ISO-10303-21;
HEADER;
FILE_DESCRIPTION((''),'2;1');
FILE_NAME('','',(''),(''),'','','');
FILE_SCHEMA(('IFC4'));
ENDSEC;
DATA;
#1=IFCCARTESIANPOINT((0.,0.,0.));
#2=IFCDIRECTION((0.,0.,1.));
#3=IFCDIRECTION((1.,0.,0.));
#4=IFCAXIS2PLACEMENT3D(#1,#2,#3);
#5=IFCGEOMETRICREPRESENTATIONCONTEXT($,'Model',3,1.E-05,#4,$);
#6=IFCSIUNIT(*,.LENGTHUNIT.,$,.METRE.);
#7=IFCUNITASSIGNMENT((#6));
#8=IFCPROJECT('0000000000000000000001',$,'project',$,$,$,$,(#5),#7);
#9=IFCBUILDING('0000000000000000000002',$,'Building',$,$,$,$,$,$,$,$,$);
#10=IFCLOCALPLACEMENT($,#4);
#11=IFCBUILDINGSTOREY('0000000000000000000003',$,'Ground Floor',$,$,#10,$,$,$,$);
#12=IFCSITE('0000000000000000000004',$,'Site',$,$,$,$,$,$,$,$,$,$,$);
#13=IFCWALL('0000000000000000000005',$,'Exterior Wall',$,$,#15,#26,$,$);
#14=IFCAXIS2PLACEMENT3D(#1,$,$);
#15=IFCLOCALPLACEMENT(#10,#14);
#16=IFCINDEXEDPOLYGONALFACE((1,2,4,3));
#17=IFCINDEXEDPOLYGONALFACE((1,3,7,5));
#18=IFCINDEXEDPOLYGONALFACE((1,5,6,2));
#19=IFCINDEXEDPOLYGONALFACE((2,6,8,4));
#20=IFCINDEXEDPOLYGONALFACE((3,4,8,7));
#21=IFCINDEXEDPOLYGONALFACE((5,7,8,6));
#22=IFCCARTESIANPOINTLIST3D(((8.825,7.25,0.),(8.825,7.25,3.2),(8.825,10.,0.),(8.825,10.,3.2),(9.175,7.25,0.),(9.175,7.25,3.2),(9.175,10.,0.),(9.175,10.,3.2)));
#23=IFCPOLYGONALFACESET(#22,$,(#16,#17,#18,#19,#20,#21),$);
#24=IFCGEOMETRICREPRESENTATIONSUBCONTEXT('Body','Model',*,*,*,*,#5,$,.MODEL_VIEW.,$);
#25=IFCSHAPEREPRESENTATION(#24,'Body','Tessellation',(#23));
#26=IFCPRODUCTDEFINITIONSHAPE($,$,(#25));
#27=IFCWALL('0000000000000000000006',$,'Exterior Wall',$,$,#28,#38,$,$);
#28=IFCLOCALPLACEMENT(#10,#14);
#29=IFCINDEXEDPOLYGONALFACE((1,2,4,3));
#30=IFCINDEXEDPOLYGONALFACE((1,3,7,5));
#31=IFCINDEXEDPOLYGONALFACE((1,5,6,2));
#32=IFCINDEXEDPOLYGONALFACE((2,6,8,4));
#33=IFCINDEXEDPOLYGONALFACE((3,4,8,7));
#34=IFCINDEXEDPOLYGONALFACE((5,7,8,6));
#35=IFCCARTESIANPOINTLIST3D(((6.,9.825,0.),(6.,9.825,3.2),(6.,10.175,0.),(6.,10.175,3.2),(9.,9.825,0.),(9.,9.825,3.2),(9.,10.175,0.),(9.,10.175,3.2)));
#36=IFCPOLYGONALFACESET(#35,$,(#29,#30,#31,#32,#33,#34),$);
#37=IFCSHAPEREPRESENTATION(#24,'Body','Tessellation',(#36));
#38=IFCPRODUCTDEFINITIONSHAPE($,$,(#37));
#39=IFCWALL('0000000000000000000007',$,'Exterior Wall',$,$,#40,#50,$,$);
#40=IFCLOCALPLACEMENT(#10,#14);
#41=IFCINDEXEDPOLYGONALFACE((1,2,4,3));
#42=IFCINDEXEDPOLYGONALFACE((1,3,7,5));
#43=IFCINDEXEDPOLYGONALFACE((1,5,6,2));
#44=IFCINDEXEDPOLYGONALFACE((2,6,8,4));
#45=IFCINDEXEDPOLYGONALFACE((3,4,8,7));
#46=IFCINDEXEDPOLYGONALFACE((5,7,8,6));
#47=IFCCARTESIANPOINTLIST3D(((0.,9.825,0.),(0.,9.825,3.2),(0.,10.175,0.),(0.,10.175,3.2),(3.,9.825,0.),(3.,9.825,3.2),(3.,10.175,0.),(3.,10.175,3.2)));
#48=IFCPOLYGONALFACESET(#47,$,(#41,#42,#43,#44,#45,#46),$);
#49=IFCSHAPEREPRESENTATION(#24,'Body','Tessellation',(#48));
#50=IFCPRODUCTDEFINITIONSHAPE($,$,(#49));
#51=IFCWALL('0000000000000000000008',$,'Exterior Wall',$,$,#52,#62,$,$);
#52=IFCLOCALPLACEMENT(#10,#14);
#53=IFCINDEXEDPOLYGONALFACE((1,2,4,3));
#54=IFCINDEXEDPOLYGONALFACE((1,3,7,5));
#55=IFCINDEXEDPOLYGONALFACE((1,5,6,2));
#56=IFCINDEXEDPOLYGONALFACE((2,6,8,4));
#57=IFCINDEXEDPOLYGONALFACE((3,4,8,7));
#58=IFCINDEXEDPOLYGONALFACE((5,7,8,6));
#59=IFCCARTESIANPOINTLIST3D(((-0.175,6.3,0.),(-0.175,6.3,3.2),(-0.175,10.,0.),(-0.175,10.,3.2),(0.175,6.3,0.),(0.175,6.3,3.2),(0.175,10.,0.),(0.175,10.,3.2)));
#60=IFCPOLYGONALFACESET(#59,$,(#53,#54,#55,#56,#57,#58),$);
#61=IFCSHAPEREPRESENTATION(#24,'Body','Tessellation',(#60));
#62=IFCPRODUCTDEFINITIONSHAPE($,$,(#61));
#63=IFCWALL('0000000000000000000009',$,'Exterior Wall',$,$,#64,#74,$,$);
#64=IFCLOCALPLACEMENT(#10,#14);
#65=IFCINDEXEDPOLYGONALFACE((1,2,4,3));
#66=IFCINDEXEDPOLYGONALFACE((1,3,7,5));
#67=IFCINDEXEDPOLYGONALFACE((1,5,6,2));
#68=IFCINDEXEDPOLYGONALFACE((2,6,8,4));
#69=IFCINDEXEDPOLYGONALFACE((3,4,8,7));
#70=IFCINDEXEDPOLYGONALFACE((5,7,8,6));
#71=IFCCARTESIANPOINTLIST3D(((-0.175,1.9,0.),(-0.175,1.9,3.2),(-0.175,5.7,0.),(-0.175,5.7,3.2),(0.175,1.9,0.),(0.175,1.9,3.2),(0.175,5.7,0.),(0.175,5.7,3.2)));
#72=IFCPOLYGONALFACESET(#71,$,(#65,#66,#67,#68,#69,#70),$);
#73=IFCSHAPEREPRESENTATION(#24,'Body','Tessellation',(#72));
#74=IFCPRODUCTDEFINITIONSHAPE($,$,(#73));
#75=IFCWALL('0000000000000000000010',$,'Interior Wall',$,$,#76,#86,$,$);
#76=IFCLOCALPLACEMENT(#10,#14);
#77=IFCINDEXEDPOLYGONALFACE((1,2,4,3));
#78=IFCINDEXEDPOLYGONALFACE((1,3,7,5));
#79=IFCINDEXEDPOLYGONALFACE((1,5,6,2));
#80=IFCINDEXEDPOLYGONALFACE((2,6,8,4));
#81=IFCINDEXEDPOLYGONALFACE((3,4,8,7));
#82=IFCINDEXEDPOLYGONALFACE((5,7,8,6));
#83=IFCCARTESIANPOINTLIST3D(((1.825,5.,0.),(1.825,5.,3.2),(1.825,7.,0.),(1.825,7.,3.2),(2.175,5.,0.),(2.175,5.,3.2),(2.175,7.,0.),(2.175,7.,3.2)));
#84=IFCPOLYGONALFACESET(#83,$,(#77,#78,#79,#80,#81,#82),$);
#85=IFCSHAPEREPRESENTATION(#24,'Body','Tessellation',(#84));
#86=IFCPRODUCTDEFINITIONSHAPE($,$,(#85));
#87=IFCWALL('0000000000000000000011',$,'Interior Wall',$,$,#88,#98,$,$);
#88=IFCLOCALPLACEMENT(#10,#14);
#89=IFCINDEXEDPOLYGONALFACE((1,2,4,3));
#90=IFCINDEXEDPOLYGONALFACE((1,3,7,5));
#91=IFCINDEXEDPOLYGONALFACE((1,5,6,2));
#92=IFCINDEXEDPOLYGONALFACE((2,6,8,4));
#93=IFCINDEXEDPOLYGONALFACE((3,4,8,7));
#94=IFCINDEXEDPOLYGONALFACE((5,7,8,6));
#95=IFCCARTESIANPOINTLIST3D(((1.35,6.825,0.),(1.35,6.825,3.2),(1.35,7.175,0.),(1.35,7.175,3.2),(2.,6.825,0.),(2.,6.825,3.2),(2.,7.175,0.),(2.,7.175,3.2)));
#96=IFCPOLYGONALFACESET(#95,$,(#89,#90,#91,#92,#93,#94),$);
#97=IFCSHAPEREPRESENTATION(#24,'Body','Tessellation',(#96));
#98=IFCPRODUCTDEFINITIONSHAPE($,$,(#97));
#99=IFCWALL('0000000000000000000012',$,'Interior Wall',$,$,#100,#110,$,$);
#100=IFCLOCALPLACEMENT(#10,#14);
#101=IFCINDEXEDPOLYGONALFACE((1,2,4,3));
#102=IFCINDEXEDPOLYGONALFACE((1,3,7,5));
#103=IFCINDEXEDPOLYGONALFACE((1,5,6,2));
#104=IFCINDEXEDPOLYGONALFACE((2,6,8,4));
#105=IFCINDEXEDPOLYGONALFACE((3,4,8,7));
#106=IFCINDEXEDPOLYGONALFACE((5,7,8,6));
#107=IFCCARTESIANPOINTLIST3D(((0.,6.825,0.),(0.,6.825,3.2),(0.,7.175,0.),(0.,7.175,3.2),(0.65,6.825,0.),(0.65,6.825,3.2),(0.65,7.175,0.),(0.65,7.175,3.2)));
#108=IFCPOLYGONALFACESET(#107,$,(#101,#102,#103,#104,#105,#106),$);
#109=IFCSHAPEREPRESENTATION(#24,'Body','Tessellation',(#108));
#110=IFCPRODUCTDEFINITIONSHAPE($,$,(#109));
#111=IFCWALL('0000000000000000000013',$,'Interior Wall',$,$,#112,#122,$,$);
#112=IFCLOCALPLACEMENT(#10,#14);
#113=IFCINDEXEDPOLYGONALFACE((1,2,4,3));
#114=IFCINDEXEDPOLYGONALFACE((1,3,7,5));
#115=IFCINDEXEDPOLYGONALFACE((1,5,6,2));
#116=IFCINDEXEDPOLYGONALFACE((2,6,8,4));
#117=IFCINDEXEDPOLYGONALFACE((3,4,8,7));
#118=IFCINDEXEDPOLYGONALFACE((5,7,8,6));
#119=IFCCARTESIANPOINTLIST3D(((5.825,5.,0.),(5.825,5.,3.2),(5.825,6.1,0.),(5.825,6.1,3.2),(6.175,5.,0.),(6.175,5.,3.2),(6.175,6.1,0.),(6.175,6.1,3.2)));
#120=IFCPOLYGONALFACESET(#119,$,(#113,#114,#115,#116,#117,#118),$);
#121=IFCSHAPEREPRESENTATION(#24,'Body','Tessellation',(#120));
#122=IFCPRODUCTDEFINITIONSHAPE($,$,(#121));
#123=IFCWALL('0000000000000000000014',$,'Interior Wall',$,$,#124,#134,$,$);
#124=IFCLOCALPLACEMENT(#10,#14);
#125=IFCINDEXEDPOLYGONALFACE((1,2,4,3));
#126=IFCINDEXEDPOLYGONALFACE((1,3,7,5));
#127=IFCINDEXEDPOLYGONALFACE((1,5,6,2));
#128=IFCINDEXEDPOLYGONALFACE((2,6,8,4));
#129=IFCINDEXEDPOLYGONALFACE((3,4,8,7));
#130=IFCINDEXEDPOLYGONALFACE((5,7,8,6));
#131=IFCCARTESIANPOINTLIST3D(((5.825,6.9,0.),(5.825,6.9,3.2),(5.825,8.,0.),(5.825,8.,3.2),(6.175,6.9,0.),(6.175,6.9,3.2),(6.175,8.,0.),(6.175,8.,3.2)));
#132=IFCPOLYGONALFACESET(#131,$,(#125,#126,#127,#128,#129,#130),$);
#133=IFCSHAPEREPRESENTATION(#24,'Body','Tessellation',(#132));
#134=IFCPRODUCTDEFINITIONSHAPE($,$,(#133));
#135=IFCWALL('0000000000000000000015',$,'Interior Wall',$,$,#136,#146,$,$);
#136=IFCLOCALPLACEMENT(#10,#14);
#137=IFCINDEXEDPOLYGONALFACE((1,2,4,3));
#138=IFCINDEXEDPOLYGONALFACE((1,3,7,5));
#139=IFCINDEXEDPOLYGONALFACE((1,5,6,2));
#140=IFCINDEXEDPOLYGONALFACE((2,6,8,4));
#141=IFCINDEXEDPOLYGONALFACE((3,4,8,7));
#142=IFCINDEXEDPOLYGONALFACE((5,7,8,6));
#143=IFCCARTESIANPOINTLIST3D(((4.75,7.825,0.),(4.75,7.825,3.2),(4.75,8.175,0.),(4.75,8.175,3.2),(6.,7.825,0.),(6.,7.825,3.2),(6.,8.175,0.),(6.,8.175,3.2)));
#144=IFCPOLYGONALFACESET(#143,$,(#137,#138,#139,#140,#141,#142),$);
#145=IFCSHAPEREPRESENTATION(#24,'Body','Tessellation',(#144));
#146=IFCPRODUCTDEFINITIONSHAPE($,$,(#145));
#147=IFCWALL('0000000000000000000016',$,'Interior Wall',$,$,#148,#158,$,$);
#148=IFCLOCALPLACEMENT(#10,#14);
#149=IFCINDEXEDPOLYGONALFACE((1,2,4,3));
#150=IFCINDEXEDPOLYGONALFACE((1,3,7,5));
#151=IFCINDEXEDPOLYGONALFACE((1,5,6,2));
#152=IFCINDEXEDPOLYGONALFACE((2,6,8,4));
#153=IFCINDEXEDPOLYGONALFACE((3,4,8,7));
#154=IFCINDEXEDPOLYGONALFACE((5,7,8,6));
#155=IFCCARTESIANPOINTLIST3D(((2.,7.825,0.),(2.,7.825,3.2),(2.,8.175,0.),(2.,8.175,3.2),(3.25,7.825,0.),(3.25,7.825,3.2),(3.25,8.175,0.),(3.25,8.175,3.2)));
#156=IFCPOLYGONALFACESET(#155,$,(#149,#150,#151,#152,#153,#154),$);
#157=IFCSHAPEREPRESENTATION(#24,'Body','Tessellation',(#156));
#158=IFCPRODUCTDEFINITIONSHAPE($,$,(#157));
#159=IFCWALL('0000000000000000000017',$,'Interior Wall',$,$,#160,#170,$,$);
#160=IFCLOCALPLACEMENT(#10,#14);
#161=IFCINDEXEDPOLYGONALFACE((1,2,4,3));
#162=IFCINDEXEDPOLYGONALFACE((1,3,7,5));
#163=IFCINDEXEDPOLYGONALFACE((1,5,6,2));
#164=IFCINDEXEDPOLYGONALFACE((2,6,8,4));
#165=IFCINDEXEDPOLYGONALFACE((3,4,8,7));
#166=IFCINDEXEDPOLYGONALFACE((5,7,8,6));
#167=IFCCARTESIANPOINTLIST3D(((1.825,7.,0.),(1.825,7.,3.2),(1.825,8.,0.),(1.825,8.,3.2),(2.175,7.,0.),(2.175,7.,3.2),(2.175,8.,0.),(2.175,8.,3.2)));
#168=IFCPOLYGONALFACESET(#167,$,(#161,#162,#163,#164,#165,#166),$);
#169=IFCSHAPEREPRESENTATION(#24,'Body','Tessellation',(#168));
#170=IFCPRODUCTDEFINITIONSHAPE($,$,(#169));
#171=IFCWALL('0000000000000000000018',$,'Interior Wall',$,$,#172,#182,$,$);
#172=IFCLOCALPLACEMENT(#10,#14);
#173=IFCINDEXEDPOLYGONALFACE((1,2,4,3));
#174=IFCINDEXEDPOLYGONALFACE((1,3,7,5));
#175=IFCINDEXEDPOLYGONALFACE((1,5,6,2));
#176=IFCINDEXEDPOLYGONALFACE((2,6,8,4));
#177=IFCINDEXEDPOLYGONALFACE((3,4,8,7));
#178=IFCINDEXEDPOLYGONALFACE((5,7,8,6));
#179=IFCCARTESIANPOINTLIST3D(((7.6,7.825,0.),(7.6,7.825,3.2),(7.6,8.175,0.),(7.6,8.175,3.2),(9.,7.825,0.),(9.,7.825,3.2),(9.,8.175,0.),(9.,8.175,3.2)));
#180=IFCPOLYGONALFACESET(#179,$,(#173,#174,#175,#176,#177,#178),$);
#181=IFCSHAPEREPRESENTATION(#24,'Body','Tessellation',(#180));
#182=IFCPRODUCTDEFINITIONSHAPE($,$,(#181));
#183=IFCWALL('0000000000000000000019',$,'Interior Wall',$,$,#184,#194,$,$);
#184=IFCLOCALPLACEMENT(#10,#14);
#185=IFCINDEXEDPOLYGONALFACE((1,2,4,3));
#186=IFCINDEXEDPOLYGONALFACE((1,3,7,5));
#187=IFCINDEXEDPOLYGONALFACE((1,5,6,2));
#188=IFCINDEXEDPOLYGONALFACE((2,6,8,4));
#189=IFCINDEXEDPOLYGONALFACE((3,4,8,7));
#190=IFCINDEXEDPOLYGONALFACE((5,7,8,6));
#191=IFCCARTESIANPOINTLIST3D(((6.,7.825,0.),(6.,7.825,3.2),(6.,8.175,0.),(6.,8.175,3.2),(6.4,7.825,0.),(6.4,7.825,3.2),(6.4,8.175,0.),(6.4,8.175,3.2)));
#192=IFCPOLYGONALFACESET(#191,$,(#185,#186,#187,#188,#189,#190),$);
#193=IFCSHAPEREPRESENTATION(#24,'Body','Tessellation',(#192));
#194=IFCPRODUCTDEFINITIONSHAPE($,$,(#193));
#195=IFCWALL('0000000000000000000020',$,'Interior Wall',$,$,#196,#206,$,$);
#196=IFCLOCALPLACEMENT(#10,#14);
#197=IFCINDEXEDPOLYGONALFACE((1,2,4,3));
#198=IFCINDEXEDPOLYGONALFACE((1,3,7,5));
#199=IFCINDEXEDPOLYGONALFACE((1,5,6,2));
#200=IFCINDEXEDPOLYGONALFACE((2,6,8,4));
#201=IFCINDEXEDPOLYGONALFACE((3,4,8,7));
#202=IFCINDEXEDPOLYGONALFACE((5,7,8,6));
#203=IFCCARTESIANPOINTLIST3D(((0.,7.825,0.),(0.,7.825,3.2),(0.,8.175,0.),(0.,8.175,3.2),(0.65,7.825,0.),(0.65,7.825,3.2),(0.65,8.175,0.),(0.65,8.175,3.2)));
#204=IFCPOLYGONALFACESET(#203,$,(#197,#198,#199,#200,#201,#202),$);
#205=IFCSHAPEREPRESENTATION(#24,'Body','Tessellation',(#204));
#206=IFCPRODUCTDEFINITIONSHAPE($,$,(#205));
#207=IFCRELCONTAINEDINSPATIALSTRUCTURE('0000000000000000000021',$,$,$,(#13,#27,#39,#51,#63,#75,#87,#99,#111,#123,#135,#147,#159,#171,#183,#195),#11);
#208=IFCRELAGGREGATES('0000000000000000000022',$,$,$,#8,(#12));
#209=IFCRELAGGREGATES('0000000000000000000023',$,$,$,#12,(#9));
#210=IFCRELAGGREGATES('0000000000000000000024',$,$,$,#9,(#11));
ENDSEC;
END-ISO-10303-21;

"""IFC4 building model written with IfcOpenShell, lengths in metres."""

from ifc_helpers import new_model, si_unit, frame, origin_with_axes, place, context, subcontext, project, spatial, indexed_curve, outline, extrude, element, save


model = new_model("IFC4")

# Units and contexts
model_context = context("Model", 3, precision=1e-05, world=origin_with_axes())
body_context = subcontext(model_context, "Body", "Model", "MODEL_VIEW")
ifc_project = project(units=[si_unit("LENGTHUNIT", "METRE")], contexts=[model_context])

# Site, building, storey
site = spatial("IfcSite", under=ifc_project, Name="Site")
building = spatial("IfcBuilding", under=site, Name="Building")
storey_placement = place(None, origin_with_axes())
storey = spatial("IfcBuildingStorey", under=building, at=storey_placement, Name="Ground Floor")

# Walls
wall_1_placement = place(storey_placement, frame((9.0, 7.25, 0.0), z_axis=(0.0, 0.0, 1.0), x_axis=(0.0, 1.0, 0.0)))
element("IfcWall", 1, at=wall_1_placement, inside=storey, Name="Exterior Wall", context=body_context, shape_type="SweptSolid", body=[
    extrude(outline(indexed_curve([(0.0, 0.0), (0.0, 0.35), (2.75, 0.35), (2.75, 0.0), (0.0, 0.0)], self_intersect=False)), frame((0.0, -0.175, 0.0), z_axis=(0.0, 0.0, 1.0), x_axis=(1.0, 0.0, 0.0)), (0.0, 0.0, 1.0), 3.2),
])
for number, where, z_axis, x_axis, name in (
    (2, (9.0, 10.0, 0.0), (0.0, 0.0, 1.0), (-1.0, 0.0, 0.0), "Exterior Wall"),
    (3, (3.0, 10.0, 0.0), (0.0, 0.0, 1.0), (-1.0, 0.0, 0.0), "Exterior Wall"),
):
    element("IfcWall", number, at=place(storey_placement, frame(where, z_axis=z_axis, x_axis=x_axis)), inside=storey, Name=name, context=body_context, shape_type="SweptSolid", body=[
        extrude(outline(indexed_curve([(0.0, 0.0), (0.0, 0.35), (3.0, 0.35), (3.0, 0.0), (0.0, 0.0)], self_intersect=False)), frame((0.0, -0.175, 0.0), z_axis=(0.0, 0.0, 1.0), x_axis=(1.0, 0.0, 0.0)), (0.0, 0.0, 1.0), 3.2),
    ])
wall_2_placement = place(storey_placement, frame((0.0, 10.0, 0.0), z_axis=(0.0, 0.0, 1.0), x_axis=(0.0, -1.0, 0.0)))
element("IfcWall", 4, at=wall_2_placement, inside=storey, Name="Exterior Wall", context=body_context, shape_type="SweptSolid", body=[
    extrude(outline(indexed_curve([(0.0, 0.0), (0.0, 0.35), (3.7, 0.35), (3.7, 0.0), (0.0, 0.0)], self_intersect=False)), frame((0.0, -0.175, 0.0), z_axis=(0.0, 0.0, 1.0), x_axis=(1.0, 0.0, 0.0)), (0.0, 0.0, 1.0), 3.2),
])
wall_3_placement = place(storey_placement, frame((0.0, 5.7, 0.0), z_axis=(0.0, 0.0, 1.0), x_axis=(0.0, -1.0, 0.0)))
element("IfcWall", 5, at=wall_3_placement, inside=storey, Name="Exterior Wall", context=body_context, shape_type="SweptSolid", body=[
    extrude(outline(indexed_curve([(0.0, 0.0), (0.0, 0.35), (3.8, 0.35), (3.8, 0.0), (0.0, 0.0)], self_intersect=False)), frame((0.0, -0.175, 0.0), z_axis=(0.0, 0.0, 1.0), x_axis=(1.0, 0.0, 0.0)), (0.0, 0.0, 1.0), 3.2),
])
wall_4_placement = place(storey_placement, frame((2.0, 5.0, 0.0), z_axis=(0.0, 0.0, 1.0), x_axis=(0.0, 1.0, 0.0)))
element("IfcWall", 6, at=wall_4_placement, inside=storey, Name="Interior Wall", context=body_context, shape_type="SweptSolid", body=[
    extrude(outline(indexed_curve([(0.0, 0.0), (0.0, 0.35), (2.0, 0.35), (2.0, 0.0), (0.0, 0.0)], self_intersect=False)), frame((0.0, -0.175, 0.0), z_axis=(0.0, 0.0, 1.0), x_axis=(1.0, 0.0, 0.0)), (0.0, 0.0, 1.0), 3.2),
])
for number, where, z_axis, x_axis, name in (
    (7, (2.0, 7.0, 0.0), (0.0, 0.0, 1.0), (-1.0, 0.0, 0.0), "Interior Wall"),
    (8, (0.65, 7.0, 0.0), (0.0, 0.0, 1.0), (-1.0, 0.0, 0.0), "Interior Wall"),
):
    element("IfcWall", number, at=place(storey_placement, frame(where, z_axis=z_axis, x_axis=x_axis)), inside=storey, Name=name, context=body_context, shape_type="SweptSolid", body=[
        extrude(outline(indexed_curve([(0.0, 0.0), (0.0, 0.35), (0.65, 0.35), (0.65, 0.0), (0.0, 0.0)], self_intersect=False)), frame((0.0, -0.175, 0.0), z_axis=(0.0, 0.0, 1.0), x_axis=(1.0, 0.0, 0.0)), (0.0, 0.0, 1.0), 3.2),
    ])
for number, where, z_axis, x_axis, name in (
    (9, (6.0, 5.0, 0.0), (0.0, 0.0, 1.0), (0.0, 1.0, 0.0), "Interior Wall"),
    (10, (6.0, 6.9, 0.0), (0.0, 0.0, 1.0), (0.0, 1.0, 0.0), "Interior Wall"),
):
    element("IfcWall", number, at=place(storey_placement, frame(where, z_axis=z_axis, x_axis=x_axis)), inside=storey, Name=name, context=body_context, shape_type="SweptSolid", body=[
        extrude(outline(indexed_curve([(0.0, 0.0), (0.0, 0.35), (1.1, 0.35), (1.1, 0.0), (0.0, 0.0)], self_intersect=False)), frame((0.0, -0.175, 0.0), z_axis=(0.0, 0.0, 1.0), x_axis=(1.0, 0.0, 0.0)), (0.0, 0.0, 1.0), 3.2),
    ])
for number, where, z_axis, x_axis, name in (
    (11, (6.0, 8.0, 0.0), (0.0, 0.0, 1.0), (-1.0, 0.0, 0.0), "Interior Wall"),
    (12, (3.25, 8.0, 0.0), (0.0, 0.0, 1.0), (-1.0, 0.0, 0.0), "Interior Wall"),
):
    element("IfcWall", number, at=place(storey_placement, frame(where, z_axis=z_axis, x_axis=x_axis)), inside=storey, Name=name, context=body_context, shape_type="SweptSolid", body=[
        extrude(outline(indexed_curve([(0.0, 0.0), (0.0, 0.35), (1.25, 0.35), (1.25, 0.0), (0.0, 0.0)], self_intersect=False)), frame((0.0, -0.175, 0.0), z_axis=(0.0, 0.0, 1.0), x_axis=(1.0, 0.0, 0.0)), (0.0, 0.0, 1.0), 3.2),
    ])
wall_5_placement = place(storey_placement, frame((2.0, 8.0, 0.0), z_axis=(0.0, 0.0, 1.0), x_axis=(0.0, -1.0, 0.0)))
element("IfcWall", 13, at=wall_5_placement, inside=storey, Name="Interior Wall", context=body_context, shape_type="SweptSolid", body=[
    extrude(outline(indexed_curve([(0.0, 0.0), (0.0, 0.35), (1.0, 0.35), (1.0, 0.0), (0.0, 0.0)], self_intersect=False)), frame((0.0, -0.175, 0.0), z_axis=(0.0, 0.0, 1.0), x_axis=(1.0, 0.0, 0.0)), (0.0, 0.0, 1.0), 3.2),
])
wall_6_placement = place(storey_placement, frame((9.0, 8.0, 0.0), z_axis=(0.0, 0.0, 1.0), x_axis=(-1.0, 0.0, 0.0)))
element("IfcWall", 14, at=wall_6_placement, inside=storey, Name="Interior Wall", context=body_context, shape_type="SweptSolid", body=[
    extrude(outline(indexed_curve([(0.0, 0.0), (0.0, 0.35), (1.4, 0.35), (1.4, 0.0), (0.0, 0.0)], self_intersect=False)), frame((0.0, -0.175, 0.0), z_axis=(0.0, 0.0, 1.0), x_axis=(1.0, 0.0, 0.0)), (0.0, 0.0, 1.0), 3.2),
])
wall_7_placement = place(storey_placement, frame((6.4, 8.0, 0.0), z_axis=(0.0, 0.0, 1.0), x_axis=(-1.0, 0.0, 0.0)))
element("IfcWall", 15, at=wall_7_placement, inside=storey, Name="Interior Wall", context=body_context, shape_type="SweptSolid", body=[
    extrude(outline(indexed_curve([(0.0, 0.0), (0.0, 0.35), (0.4, 0.35), (0.4, 0.0), (0.0, 0.0)], self_intersect=False)), frame((0.0, -0.175, 0.0), z_axis=(0.0, 0.0, 1.0), x_axis=(1.0, 0.0, 0.0)), (0.0, 0.0, 1.0), 3.2),
])
wall_8_placement = place(storey_placement, frame((0.0, 8.0, 0.0), z_axis=(0.0, 0.0, 1.0), x_axis=(1.0, 0.0, 0.0)))
element("IfcWall", 16, at=wall_8_placement, inside=storey, Name="Interior Wall", context=body_context, shape_type="SweptSolid", body=[
    extrude(outline(indexed_curve([(0.0, 0.0), (0.0, 0.35), (0.65, 0.35), (0.65, 0.0), (0.0, 0.0)], self_intersect=False)), frame((0.0, -0.175, 0.0), z_axis=(0.0, 0.0, 1.0), x_axis=(1.0, 0.0, 0.0)), (0.0, 0.0, 1.0), 3.2),
])

save(model, "model.ifc")
